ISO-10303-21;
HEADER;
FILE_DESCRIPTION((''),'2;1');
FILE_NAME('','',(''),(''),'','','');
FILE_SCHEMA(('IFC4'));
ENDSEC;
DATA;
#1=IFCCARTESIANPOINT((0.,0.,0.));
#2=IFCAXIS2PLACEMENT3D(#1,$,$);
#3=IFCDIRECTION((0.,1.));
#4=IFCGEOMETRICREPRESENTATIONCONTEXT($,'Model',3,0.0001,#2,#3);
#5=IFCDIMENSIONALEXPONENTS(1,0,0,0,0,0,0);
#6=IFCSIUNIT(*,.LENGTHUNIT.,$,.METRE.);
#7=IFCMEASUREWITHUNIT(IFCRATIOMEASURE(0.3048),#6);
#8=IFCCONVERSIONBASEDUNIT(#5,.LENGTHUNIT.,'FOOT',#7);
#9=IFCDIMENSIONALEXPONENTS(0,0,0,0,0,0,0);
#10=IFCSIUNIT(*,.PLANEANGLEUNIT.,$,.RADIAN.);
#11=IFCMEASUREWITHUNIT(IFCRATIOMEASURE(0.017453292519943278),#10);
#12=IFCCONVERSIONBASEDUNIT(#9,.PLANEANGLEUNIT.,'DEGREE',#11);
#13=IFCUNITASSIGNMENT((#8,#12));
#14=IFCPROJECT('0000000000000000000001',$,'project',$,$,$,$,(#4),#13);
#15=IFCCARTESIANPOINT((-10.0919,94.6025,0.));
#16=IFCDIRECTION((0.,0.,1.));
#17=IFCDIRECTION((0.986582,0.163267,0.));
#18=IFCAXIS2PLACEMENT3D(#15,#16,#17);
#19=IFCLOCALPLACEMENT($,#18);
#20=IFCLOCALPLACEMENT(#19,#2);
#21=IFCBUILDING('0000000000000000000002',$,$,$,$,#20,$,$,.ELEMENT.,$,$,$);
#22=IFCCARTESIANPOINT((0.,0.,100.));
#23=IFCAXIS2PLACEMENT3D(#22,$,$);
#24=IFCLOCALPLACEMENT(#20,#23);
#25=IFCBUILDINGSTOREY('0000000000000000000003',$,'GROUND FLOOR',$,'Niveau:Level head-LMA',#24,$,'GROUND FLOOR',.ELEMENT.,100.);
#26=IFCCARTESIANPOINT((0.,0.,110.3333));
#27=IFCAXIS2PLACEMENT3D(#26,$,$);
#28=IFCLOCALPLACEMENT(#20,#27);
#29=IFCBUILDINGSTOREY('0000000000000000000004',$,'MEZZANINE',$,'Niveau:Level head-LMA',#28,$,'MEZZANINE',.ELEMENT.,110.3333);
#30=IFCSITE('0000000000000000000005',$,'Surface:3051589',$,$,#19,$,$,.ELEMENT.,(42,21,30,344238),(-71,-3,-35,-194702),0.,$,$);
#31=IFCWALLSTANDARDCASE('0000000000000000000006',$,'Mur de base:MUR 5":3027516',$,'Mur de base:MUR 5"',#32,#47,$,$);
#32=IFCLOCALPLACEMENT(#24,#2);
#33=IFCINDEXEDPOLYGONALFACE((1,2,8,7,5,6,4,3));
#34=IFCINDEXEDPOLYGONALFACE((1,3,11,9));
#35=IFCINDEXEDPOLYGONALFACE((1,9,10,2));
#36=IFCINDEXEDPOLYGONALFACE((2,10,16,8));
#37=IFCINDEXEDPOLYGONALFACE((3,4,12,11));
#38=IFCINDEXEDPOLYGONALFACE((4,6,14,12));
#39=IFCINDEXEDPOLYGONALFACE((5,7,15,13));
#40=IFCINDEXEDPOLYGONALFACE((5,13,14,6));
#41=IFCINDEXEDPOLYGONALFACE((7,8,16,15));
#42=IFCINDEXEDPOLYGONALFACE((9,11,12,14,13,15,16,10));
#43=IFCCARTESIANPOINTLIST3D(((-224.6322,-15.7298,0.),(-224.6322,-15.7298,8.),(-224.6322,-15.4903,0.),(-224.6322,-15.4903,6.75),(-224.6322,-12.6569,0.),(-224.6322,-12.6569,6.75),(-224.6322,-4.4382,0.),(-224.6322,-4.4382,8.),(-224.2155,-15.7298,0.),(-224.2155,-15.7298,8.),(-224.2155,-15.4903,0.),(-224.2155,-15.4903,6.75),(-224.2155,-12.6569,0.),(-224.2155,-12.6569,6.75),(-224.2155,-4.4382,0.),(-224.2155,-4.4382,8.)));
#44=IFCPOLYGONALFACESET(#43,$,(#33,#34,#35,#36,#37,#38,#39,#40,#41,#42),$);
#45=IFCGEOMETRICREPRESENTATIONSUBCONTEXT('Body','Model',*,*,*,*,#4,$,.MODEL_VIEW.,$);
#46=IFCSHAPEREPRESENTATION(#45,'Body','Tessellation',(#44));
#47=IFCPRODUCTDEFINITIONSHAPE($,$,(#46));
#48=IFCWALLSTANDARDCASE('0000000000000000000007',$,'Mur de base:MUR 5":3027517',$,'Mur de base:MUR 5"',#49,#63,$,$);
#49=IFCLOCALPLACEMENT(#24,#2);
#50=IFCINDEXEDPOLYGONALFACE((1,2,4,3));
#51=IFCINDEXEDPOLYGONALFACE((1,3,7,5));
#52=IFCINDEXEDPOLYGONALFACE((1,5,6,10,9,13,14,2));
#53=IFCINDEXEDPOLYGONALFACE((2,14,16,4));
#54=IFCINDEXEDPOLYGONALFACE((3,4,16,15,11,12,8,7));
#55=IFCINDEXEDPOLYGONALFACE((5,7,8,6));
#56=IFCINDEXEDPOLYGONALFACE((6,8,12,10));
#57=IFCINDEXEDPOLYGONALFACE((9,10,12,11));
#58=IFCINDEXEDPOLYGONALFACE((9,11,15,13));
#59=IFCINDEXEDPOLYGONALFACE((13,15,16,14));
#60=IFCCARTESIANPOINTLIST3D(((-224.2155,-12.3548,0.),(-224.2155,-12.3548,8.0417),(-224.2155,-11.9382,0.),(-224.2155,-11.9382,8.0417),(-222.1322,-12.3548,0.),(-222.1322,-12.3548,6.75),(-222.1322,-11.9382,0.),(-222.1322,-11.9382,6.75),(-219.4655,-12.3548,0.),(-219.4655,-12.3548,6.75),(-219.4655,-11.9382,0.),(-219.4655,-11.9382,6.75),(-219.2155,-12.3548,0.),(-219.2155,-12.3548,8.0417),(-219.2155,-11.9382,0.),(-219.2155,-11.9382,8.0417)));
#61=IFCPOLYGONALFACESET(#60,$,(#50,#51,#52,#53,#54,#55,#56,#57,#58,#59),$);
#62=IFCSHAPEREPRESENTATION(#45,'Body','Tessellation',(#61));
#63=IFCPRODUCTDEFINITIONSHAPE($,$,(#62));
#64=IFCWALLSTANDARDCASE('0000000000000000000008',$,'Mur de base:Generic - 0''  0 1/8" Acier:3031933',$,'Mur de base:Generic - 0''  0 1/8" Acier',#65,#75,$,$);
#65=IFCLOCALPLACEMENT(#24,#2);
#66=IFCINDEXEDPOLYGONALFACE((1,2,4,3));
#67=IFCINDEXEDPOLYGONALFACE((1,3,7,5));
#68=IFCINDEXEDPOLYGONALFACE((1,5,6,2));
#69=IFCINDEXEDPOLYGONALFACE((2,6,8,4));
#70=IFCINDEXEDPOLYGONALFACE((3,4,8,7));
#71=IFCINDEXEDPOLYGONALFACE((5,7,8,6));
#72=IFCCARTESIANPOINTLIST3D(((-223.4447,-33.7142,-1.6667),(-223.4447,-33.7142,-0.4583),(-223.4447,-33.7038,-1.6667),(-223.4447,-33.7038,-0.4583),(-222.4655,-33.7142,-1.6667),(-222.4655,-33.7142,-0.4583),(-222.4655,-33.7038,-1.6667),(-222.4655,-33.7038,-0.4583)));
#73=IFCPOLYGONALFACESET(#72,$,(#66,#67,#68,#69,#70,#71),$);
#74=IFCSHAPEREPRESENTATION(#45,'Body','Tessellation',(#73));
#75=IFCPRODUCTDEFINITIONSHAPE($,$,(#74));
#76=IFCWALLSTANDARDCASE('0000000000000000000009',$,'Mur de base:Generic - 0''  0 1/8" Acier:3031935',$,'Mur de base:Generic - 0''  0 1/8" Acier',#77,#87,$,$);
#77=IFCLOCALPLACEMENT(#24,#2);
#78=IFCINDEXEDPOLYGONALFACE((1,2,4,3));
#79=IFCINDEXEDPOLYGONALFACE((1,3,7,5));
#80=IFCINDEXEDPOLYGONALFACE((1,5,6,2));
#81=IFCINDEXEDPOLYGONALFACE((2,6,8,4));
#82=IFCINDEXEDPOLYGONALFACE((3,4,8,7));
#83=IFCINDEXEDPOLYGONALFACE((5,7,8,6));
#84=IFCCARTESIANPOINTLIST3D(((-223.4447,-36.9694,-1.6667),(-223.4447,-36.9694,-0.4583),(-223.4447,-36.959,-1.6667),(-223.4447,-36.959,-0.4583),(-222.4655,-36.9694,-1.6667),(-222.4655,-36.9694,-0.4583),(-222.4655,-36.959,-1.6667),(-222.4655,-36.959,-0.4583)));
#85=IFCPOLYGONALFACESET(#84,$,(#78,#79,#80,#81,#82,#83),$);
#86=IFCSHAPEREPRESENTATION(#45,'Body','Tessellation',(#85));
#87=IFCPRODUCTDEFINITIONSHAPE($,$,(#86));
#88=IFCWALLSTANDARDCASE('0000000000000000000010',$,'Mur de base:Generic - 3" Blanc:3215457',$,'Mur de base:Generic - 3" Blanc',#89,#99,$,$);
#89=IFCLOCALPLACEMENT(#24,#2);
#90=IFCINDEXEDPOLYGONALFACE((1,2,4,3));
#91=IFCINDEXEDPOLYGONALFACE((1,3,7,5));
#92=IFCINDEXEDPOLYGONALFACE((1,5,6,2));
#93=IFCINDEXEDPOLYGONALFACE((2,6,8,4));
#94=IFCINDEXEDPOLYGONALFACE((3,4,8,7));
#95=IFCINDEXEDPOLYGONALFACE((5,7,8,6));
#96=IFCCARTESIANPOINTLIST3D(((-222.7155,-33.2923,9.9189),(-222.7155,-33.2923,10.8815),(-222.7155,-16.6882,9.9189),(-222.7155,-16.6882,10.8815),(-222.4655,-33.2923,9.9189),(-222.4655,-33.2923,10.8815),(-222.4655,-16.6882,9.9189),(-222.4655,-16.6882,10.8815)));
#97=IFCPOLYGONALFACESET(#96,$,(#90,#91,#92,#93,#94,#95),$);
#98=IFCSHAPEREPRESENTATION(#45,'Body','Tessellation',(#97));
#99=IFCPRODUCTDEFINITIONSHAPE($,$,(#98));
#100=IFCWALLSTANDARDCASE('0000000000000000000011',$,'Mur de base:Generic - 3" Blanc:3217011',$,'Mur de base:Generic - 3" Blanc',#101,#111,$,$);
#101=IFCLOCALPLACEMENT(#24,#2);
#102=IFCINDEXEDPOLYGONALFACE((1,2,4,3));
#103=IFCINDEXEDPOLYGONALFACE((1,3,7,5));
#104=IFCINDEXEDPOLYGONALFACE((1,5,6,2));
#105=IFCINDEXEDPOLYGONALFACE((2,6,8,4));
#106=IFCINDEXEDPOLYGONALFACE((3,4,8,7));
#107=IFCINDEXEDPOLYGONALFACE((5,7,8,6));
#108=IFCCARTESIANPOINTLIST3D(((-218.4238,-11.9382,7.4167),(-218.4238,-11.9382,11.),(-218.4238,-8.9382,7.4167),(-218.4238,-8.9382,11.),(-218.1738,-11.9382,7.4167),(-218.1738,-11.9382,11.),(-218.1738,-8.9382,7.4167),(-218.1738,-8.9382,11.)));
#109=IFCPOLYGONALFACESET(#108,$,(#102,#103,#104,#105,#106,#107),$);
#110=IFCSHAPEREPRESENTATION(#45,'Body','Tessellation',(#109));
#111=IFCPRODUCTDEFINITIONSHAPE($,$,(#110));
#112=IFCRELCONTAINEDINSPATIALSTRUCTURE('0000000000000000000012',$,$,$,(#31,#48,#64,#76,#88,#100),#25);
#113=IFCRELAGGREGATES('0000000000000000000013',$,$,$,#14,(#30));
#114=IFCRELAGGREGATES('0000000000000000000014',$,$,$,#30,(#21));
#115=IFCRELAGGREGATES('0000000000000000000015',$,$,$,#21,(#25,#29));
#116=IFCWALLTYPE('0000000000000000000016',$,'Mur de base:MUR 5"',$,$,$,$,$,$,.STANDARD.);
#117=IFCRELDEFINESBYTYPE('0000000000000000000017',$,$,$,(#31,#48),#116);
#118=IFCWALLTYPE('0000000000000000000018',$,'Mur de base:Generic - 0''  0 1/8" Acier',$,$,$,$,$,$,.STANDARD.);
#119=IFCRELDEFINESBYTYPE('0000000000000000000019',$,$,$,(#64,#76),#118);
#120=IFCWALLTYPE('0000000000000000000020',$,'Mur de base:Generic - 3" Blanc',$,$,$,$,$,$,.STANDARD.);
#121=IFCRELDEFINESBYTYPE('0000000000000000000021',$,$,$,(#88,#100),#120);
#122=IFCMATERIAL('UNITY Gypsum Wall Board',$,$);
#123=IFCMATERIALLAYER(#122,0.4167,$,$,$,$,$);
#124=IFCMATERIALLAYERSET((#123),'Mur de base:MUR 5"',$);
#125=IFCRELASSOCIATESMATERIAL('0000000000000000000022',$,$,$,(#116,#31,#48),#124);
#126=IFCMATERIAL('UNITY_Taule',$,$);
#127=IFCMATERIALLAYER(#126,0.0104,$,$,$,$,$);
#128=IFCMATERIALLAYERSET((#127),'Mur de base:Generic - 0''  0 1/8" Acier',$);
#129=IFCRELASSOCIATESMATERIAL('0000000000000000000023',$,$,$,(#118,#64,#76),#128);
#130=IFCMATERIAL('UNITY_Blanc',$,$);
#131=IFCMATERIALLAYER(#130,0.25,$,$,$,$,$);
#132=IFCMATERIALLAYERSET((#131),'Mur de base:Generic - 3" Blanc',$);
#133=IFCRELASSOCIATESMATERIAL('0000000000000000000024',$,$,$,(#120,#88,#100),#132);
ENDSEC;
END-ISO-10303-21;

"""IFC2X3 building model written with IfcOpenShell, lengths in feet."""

from ifc_helpers import new_model, entity, si_unit, converted_unit, direction, frame, frame_2d, origin, place, context, subcontext, project, spatial, rectangle, extrude, material, layer, layer_set, layer_usage, type_object, element, save


model = new_model("IFC2X3")

# Units and contexts
model_context = context("Model", 3, precision=0.0001, world=origin(), true_north=direction((0.0, 1.0)))
body_context = subcontext(model_context, "Body", "Model", "MODEL_VIEW")
ifc_project = project(units=[converted_unit("LENGTHUNIT", "FOOT", entity("IfcRatioMeasure", 0.3048), si_unit("LENGTHUNIT", "METRE"), dimensions=[1, 0, 0, 0, 0, 0, 0]), converted_unit("PLANEANGLEUNIT", "DEGREE", entity("IfcRatioMeasure", 0.017453292519943278), si_unit("PLANEANGLEUNIT", "RADIAN"), dimensions=[0, 0, 0, 0, 0, 0, 0])], contexts=[model_context])

# Site, building, storey
site_placement = place(None, frame((-10.0919, 94.6025, 0.0), z_axis=(0.0, 0.0, 1.0), x_axis=(0.986582, 0.163267, 0.0)))
site = spatial("IfcSite", under=ifc_project, at=site_placement, Name="Surface:3051589", CompositionType="ELEMENT", RefLatitude=(42, 21, 30, 344238), RefLongitude=(-71, -3, -35, -194702), RefElevation=0.0)
building_placement = place(site_placement, origin())
building = spatial("IfcBuilding", under=site, at=building_placement, CompositionType="ELEMENT")
storey_1_placement = place(building_placement, frame((0.0, 0.0, 100.0)))
storey_1 = spatial("IfcBuildingStorey", under=building, at=storey_1_placement, Name="GROUND FLOOR", ObjectType="Niveau:Level head-LMA", LongName="GROUND FLOOR", CompositionType="ELEMENT", Elevation=100.0)

# Shared definitions
ifc_material_1 = material(Name="UNITY_Blanc")

# Shared definitions
storey_2_placement = place(building_placement, frame((0.0, 0.0, 110.3333)))
storey_2 = spatial("IfcBuildingStorey", under=building, at=storey_2_placement, Name="MEZZANINE", ObjectType="Niveau:Level head-LMA", LongName="MEZZANINE", CompositionType="ELEMENT", Elevation=110.3333)

# Walls, openings
ifc_material_2 = material(Name="UNITY Gypsum Wall Board")
ifc_layer_1 = layer(ifc_material_2, 0.4167)
ifc_layer_set_1 = layer_set([ifc_layer_1], Name="Mur de base:MUR 5\"")
ifc_layer_usage_1 = layer_usage(ifc_layer_set_1, "AXIS2", "NEGATIVE", 0.2083)
wall_type_1 = type_object("IfcWallType", Name="Mur de base:MUR 5\"", PredefinedType="STANDARD", material=ifc_layer_set_1)
wall_1_placement = place(storey_1_placement, frame((-224.4238, -15.7298, 0.0), z_axis=(0.0, 0.0, 1.0), x_axis=(0.0, 1.0, 0.0)))
wall_1 = element("IfcWallStandardCase", 1, at=wall_1_placement, inside=storey_1, type_object=wall_type_1, material=ifc_layer_usage_1, Name="Mur de base:MUR 5\":3027516", ObjectType="Mur de base:MUR 5\"", context=body_context, shape_type="SweptSolid", body=[
    extrude(rectangle(XDim=11.2917, YDim=0.4167, at=frame_2d((5.6458, 0.0), x_axis=(-1.0, 0.0))), origin(), (0.0, 0.0, 1.0), 8.0),
])
opening_1_placement = place(wall_1_placement, frame((15.7298, -224.4238, 0.0), z_axis=(0.0, 0.0, 1.0), x_axis=(0.0, -1.0, 0.0)))
element("IfcOpeningElement", 2, at=opening_1_placement, cuts=wall_1, ObjectType="Opening", context=body_context, shape_type="SweptSolid", body=[
    extrude(rectangle(XDim=6.75, YDim=2.8333, at=frame_2d((0.0, 0.0), x_axis=(1.0, 0.0))), frame((-219.2155, -14.0736, 3.375), z_axis=(-1.0, 0.0, 0.0), x_axis=(0.0, 0.0, 1.0)), (0.0, 0.0, 1.0), 10.0),
])
ifc_layer_usage_2 = layer_usage(ifc_layer_set_1, "AXIS2", "POSITIVE", -0.2083)
wall_2_placement = place(storey_1_placement, frame((-224.2155, -12.1465, 0.0)))
wall_2 = element("IfcWallStandardCase", 3, at=wall_2_placement, inside=storey_1, type_object=wall_type_1, material=ifc_layer_usage_2, Name="Mur de base:MUR 5\":3027517", ObjectType="Mur de base:MUR 5\"", context=body_context, shape_type="SweptSolid", body=[
    extrude(rectangle(XDim=5.0, YDim=0.4167, at=frame_2d((2.5, 0.0), x_axis=(-1.0, 0.0))), origin(), (0.0, 0.0, 1.0), 8.0417),
])
opening_2_placement = place(wall_2_placement, frame((224.2155, 12.1465, 0.0)))
element("IfcOpeningElement", 4, at=opening_2_placement, cuts=wall_2, ObjectType="Opening", context=body_context, shape_type="SweptSolid", body=[
    extrude(rectangle(XDim=6.75, YDim=2.6667, at=frame_2d((0.0, 0.0), x_axis=(0.0, 1.0))), frame((-220.7988, -17.3548, 3.375), z_axis=(0.0, 1.0, 0.0), x_axis=(-1.0, 0.0, 0.0)), (0.0, 0.0, 1.0), 10.0),
])

# Walls
ifc_material_3 = material(Name="UNITY_Taule")
ifc_layer_2 = layer(ifc_material_3, 0.0104)
ifc_layer_set_2 = layer_set([ifc_layer_2], Name="Mur de base:Generic - 0'  0 1/8\" Acier")
ifc_layer_usage_3 = layer_usage(ifc_layer_set_2, "AXIS2", "NEGATIVE", 0.0052)
wall_type_2 = type_object("IfcWallType", Name="Mur de base:Generic - 0'  0 1/8\" Acier", PredefinedType="STANDARD", material=ifc_layer_set_2)
wall_3_placement = place(storey_1_placement, frame((-222.4655, -33.709, -1.6667), z_axis=(0.0, 0.0, 1.0), x_axis=(-1.0, 0.0, 0.0)))
element("IfcWallStandardCase", 5, at=wall_3_placement, inside=storey_1, type_object=wall_type_2, material=ifc_layer_usage_3, Name="Mur de base:Generic - 0'  0 1/8\" Acier:3031933", ObjectType="Mur de base:Generic - 0'  0 1/8\" Acier", context=body_context, shape_type="SweptSolid", body=[
    extrude(rectangle(XDim=0.9792, YDim=0.0104, at=frame_2d((0.4896, 0.0), x_axis=(-1.0, 0.0))), origin(), (0.0, 0.0, 1.0), 1.2083),
])
ifc_layer_usage_4 = layer_usage(ifc_layer_set_2, "AXIS2", "POSITIVE", -0.0052)
wall_4_placement = place(storey_1_placement, frame((-222.4655, -36.9642, -1.6667), z_axis=(0.0, 0.0, 1.0), x_axis=(-1.0, 0.0, 0.0)))
element("IfcWallStandardCase", 6, at=wall_4_placement, inside=storey_1, type_object=wall_type_2, material=ifc_layer_usage_4, Name="Mur de base:Generic - 0'  0 1/8\" Acier:3031935", ObjectType="Mur de base:Generic - 0'  0 1/8\" Acier", context=body_context, shape_type="SweptSolid", body=[
    extrude(rectangle(XDim=0.9792, YDim=0.0104, at=frame_2d((0.4896, 0.0), x_axis=(-1.0, 0.0))), origin(), (0.0, 0.0, 1.0), 1.2083),
])
ifc_layer_3 = layer(ifc_material_1, 0.25)
ifc_layer_set_3 = layer_set([ifc_layer_3], Name="Mur de base:Generic - 3\" Blanc")
ifc_layer_usage_5 = layer_usage(ifc_layer_set_3, "AXIS2", "POSITIVE", -0.125)
wall_type_3 = type_object("IfcWallType", Name="Mur de base:Generic - 3\" Blanc", PredefinedType="STANDARD", material=ifc_layer_set_3)
wall_5_placement = place(storey_1_placement, frame((-222.5905, -16.6882, 9.9189), z_axis=(0.0, 0.0, 1.0), x_axis=(0.0, -1.0, 0.0)))
element("IfcWallStandardCase", 7, at=wall_5_placement, inside=storey_1, type_object=wall_type_3, material=ifc_layer_usage_5, Name="Mur de base:Generic - 3\" Blanc:3215457", ObjectType="Mur de base:Generic - 3\" Blanc", context=body_context, shape_type="SweptSolid", body=[
    extrude(rectangle(XDim=16.6042, YDim=0.25, at=frame_2d((8.3021, 0.0), x_axis=(-1.0, 0.0))), origin(), (0.0, 0.0, 1.0), 0.9627),
])
ifc_layer_usage_6 = layer_usage(ifc_layer_set_3, "AXIS2", "POSITIVE", -0.125)
wall_6_placement = place(storey_1_placement, frame((-218.2988, -11.9382, 7.4167), z_axis=(0.0, 0.0, 1.0), x_axis=(0.0, 1.0, 0.0)))
element("IfcWallStandardCase", 8, at=wall_6_placement, inside=storey_1, type_object=wall_type_3, material=ifc_layer_usage_6, Name="Mur de base:Generic - 3\" Blanc:3217011", ObjectType="Mur de base:Generic - 3\" Blanc", context=body_context, shape_type="SweptSolid", body=[
    extrude(rectangle(XDim=3.0, YDim=0.25, at=frame_2d((1.5, 0.0), x_axis=(-1.0, 0.0))), origin(), (0.0, 0.0, 1.0), 3.5833),
])

save(model, "model.ifc")
